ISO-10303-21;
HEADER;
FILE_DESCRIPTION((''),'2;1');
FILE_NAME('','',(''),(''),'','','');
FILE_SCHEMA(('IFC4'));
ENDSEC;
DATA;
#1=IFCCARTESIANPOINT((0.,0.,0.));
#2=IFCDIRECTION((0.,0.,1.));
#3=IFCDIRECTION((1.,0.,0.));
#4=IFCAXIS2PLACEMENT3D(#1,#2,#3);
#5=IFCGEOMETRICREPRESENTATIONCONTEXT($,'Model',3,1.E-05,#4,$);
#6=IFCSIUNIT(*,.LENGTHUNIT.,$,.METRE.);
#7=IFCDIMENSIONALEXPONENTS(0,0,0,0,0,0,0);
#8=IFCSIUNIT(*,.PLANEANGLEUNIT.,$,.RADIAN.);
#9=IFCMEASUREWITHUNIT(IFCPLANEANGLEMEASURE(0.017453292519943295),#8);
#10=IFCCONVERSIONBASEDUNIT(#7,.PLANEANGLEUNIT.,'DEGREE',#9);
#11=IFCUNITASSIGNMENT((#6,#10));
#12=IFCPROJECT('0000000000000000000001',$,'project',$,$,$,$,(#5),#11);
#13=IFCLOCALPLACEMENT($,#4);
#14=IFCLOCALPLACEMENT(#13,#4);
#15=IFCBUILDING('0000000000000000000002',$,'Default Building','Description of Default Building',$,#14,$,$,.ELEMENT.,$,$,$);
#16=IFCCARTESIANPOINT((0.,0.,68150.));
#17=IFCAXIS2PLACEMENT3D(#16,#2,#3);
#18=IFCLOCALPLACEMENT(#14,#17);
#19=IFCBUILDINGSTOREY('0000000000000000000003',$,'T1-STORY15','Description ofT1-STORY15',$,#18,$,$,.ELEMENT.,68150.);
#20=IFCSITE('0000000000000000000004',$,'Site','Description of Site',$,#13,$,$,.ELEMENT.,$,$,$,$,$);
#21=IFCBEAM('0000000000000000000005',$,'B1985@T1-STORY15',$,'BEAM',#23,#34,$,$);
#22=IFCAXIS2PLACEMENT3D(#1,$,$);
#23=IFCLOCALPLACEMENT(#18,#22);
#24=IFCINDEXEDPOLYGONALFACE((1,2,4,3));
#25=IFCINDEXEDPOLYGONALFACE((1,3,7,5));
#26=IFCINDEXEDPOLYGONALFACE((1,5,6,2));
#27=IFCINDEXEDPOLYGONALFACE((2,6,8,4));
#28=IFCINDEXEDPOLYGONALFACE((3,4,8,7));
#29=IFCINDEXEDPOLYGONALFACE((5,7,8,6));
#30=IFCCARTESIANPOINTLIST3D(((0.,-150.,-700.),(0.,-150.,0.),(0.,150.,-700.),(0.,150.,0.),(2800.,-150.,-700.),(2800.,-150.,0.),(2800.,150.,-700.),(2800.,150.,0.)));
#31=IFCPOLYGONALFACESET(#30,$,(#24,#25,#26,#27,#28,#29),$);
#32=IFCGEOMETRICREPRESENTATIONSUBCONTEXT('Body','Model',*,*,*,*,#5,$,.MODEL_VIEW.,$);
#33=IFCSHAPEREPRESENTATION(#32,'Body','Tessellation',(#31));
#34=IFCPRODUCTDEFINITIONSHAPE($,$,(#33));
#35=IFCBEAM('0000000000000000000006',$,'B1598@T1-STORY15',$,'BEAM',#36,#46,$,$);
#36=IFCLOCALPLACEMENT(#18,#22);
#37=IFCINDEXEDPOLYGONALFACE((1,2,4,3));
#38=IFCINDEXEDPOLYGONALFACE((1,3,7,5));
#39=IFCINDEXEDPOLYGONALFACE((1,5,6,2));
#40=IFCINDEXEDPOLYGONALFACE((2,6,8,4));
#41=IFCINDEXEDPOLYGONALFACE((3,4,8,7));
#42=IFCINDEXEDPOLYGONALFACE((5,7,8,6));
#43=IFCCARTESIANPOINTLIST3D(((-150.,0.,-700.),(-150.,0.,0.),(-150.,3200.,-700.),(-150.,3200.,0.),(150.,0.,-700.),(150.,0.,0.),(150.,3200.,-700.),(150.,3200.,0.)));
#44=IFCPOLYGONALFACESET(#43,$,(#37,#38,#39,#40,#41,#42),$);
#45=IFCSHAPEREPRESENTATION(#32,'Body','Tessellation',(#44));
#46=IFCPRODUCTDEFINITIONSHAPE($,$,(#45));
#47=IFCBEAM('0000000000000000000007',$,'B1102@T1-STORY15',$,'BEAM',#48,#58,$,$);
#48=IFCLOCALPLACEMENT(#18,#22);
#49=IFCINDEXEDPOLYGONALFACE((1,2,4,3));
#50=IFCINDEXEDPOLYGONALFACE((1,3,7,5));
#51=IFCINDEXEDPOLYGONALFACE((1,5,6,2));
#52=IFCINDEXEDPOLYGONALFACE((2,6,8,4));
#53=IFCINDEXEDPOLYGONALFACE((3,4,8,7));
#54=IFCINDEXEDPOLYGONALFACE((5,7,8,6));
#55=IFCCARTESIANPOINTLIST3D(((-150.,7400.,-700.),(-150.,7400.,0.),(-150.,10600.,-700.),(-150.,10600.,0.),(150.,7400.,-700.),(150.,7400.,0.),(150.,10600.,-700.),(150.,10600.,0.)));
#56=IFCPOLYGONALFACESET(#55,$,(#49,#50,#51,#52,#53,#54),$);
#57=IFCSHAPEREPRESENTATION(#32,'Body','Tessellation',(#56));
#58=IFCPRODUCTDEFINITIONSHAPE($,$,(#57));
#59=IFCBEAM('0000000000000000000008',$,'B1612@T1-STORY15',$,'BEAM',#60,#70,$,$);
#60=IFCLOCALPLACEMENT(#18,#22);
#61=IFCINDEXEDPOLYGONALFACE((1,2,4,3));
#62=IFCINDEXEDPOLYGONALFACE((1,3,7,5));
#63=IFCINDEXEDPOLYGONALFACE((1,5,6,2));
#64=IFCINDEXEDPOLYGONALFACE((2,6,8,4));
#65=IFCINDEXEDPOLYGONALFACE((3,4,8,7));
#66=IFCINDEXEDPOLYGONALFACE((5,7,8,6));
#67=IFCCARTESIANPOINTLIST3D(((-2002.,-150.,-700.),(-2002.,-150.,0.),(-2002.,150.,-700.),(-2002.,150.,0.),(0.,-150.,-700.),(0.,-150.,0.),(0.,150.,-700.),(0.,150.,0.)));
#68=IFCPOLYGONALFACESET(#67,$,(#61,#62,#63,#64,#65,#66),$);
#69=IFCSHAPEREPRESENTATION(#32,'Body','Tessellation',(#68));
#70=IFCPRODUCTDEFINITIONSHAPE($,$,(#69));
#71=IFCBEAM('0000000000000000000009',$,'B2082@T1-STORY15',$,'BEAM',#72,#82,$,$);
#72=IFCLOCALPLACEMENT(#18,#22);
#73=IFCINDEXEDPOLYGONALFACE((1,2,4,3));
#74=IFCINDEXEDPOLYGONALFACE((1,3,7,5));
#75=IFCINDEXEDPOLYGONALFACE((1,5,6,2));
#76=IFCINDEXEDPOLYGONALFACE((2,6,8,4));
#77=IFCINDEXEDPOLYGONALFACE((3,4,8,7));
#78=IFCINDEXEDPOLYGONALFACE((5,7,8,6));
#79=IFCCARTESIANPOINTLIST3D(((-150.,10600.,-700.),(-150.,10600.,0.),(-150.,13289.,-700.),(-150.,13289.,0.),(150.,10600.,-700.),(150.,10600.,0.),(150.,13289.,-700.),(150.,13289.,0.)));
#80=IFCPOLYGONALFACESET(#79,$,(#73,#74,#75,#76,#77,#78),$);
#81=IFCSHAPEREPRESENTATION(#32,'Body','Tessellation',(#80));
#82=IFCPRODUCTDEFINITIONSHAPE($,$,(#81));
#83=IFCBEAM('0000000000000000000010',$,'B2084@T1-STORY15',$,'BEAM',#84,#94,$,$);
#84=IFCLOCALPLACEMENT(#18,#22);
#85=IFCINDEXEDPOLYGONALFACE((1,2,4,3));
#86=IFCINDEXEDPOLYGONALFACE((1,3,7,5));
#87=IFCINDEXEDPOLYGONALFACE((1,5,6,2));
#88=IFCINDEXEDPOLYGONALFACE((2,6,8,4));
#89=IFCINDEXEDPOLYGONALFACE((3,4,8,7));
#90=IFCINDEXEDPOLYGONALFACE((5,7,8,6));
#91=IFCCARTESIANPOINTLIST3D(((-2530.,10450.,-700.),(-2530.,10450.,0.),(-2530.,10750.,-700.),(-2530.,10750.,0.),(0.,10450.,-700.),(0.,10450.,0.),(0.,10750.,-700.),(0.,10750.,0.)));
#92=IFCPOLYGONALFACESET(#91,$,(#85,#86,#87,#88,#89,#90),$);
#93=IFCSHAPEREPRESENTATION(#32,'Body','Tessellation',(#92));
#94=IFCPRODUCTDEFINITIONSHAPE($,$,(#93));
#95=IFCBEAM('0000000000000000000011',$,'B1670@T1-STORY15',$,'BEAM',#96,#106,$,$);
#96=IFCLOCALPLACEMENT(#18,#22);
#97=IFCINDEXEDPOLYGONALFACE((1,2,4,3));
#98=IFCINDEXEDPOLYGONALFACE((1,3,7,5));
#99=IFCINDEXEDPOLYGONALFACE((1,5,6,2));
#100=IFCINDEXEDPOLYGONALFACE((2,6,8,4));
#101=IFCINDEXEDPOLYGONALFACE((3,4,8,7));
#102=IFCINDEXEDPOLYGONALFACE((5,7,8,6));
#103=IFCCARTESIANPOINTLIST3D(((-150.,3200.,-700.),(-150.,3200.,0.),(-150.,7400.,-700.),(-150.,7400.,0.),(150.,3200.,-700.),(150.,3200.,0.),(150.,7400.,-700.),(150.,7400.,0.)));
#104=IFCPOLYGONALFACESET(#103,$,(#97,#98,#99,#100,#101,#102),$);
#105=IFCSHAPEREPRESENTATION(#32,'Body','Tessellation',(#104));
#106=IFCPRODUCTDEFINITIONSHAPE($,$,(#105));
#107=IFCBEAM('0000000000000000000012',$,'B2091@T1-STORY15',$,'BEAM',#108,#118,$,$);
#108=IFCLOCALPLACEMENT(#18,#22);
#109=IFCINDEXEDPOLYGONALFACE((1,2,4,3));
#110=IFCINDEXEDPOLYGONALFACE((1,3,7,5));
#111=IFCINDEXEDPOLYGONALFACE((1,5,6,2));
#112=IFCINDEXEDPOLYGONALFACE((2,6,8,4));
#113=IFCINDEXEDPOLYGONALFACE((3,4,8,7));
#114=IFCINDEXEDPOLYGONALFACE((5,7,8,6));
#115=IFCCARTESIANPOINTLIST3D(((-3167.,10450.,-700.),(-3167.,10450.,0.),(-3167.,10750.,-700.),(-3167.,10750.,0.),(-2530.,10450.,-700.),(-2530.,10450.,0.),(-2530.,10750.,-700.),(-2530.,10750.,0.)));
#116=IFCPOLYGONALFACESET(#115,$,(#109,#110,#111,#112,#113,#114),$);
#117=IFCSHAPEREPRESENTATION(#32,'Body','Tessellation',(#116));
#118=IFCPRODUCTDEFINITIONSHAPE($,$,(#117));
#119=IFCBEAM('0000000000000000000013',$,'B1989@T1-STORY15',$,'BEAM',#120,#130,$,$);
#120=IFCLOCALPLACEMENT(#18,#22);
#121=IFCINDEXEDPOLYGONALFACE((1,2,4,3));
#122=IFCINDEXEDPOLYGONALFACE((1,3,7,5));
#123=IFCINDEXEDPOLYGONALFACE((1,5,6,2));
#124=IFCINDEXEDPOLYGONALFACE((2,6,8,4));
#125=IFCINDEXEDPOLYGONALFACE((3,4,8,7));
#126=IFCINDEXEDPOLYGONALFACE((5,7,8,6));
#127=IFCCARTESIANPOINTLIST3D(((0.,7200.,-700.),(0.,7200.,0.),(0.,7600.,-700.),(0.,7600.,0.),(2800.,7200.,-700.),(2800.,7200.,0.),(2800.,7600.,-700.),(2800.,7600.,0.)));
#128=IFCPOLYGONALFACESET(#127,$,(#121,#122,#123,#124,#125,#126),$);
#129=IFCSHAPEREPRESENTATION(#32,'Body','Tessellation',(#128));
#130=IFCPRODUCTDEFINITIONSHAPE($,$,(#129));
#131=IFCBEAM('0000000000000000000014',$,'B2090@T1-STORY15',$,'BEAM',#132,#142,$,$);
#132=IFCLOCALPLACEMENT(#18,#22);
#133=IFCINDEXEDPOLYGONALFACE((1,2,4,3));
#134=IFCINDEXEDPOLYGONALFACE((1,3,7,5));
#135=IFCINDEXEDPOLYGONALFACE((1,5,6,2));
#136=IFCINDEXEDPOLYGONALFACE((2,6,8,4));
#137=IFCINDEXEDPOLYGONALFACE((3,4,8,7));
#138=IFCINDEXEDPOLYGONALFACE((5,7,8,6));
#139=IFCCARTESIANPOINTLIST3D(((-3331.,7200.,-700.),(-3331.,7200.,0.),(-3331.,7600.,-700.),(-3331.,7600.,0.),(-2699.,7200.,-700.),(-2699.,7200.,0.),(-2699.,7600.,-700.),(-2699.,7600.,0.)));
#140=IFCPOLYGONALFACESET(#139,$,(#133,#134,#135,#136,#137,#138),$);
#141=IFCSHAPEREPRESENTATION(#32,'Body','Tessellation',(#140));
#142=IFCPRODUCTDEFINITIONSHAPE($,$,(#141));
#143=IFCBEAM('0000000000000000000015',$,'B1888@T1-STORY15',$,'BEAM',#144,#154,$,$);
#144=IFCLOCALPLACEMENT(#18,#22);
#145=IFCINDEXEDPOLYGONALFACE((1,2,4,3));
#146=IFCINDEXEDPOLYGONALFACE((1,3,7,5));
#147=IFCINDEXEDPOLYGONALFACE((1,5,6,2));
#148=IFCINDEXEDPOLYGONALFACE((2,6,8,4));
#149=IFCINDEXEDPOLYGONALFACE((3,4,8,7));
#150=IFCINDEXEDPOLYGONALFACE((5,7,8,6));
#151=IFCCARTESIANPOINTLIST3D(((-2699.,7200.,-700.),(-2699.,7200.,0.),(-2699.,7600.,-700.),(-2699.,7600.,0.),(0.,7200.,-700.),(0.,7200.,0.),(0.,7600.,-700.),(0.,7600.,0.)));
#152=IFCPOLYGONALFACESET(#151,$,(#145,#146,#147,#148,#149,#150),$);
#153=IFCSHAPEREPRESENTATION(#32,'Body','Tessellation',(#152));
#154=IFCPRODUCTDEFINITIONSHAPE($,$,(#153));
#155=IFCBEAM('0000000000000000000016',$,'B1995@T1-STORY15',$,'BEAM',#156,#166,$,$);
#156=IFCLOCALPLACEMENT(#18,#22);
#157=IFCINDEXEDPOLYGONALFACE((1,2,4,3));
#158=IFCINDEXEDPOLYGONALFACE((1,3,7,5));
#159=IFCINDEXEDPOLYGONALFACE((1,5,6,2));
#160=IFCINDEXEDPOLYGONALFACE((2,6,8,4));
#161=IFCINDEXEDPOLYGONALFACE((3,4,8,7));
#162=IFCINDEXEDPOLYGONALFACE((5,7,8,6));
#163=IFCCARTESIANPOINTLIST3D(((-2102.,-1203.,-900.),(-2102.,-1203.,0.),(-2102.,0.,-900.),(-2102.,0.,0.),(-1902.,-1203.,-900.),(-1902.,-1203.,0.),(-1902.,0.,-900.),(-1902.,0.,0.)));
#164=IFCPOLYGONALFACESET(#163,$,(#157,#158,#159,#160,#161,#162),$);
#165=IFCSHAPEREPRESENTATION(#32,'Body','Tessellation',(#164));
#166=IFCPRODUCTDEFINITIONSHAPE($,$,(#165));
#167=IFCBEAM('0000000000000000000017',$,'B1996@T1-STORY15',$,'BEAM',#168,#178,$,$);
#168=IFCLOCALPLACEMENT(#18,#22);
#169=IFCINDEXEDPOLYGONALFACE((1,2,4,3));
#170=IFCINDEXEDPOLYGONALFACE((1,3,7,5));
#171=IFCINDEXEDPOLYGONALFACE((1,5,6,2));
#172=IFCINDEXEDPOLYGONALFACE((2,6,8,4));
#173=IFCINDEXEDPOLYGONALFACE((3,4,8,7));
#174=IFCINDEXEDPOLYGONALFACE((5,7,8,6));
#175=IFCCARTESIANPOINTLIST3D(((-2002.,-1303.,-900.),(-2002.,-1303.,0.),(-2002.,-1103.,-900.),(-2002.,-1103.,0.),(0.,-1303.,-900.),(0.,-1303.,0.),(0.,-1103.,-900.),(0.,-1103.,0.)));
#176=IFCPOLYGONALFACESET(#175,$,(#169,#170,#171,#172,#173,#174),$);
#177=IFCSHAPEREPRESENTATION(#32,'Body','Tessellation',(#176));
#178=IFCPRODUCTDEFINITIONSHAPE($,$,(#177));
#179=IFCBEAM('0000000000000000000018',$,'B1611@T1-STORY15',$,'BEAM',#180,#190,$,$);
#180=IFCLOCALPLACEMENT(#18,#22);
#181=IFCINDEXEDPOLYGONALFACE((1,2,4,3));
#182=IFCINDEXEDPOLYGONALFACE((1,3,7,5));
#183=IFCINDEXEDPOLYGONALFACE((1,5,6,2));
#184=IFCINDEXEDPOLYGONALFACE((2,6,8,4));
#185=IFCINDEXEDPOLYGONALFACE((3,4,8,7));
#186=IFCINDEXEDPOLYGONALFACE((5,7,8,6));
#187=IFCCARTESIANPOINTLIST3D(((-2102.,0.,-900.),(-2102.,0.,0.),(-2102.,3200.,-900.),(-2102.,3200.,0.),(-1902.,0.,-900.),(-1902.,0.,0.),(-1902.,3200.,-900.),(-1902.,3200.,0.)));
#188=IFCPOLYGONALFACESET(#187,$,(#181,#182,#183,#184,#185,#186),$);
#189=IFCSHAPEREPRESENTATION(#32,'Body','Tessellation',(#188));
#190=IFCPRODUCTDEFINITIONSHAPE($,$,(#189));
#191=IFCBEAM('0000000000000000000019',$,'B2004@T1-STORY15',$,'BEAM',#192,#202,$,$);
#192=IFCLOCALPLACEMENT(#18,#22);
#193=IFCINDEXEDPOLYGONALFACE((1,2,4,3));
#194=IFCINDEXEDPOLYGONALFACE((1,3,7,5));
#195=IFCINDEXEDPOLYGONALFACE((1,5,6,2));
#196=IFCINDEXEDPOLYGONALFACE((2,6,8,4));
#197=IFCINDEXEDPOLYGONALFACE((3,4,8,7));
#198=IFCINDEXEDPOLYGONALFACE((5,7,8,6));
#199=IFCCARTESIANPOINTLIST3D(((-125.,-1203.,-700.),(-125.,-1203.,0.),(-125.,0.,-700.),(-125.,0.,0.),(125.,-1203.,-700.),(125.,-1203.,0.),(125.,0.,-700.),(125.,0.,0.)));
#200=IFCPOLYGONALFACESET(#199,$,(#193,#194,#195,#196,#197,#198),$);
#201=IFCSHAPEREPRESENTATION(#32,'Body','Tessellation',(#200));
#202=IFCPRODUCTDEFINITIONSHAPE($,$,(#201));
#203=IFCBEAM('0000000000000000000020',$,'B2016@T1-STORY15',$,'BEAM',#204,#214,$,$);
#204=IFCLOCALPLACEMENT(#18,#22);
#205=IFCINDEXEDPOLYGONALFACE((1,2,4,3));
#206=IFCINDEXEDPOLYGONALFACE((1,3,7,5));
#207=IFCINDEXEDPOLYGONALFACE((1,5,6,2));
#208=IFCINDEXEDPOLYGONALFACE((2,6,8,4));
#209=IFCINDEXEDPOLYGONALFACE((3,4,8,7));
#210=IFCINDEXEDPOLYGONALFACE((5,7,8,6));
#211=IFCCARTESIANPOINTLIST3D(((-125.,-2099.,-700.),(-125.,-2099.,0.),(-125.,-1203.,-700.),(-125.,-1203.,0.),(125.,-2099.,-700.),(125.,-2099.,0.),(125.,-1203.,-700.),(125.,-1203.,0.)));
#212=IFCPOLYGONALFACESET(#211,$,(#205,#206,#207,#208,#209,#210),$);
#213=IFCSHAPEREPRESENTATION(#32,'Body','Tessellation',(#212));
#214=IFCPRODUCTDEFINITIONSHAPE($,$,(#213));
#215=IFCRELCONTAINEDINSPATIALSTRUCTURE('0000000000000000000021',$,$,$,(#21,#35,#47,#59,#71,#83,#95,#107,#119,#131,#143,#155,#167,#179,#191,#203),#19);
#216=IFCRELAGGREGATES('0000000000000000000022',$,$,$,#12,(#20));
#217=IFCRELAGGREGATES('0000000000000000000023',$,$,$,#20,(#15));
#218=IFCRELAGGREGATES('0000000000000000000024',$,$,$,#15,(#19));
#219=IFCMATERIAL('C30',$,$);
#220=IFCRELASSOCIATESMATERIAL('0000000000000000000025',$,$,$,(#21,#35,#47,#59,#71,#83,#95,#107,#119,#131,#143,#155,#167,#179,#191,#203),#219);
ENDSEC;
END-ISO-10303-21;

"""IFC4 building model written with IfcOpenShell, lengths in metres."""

from ifc_helpers import new_model, entity, si_unit, converted_unit, frame, origin_with_axes, place, context, subcontext, project, spatial, rectangle, extrude, material, element, save


model = new_model("IFC4")

# Units and contexts
model_context = context("Model", 3, precision=1e-05, world=origin_with_axes())
body_context = subcontext(model_context, "Body", "Model", "MODEL_VIEW")
ifc_project = project(units=[si_unit("LENGTHUNIT", "METRE"), converted_unit("PLANEANGLEUNIT", "DEGREE", entity("IfcPlaneAngleMeasure", 0.017453292519943295), si_unit("PLANEANGLEUNIT", "RADIAN"), dimensions=[0, 0, 0, 0, 0, 0, 0])], contexts=[model_context])

# Site, building, storey
site_placement = place(None, origin_with_axes())
site = spatial("IfcSite", under=ifc_project, at=site_placement, Name="Site", Description="Description of Site", CompositionType="ELEMENT")
building_placement = place(site_placement, origin_with_axes())
building = spatial("IfcBuilding", under=site, at=building_placement, Name="Default Building", Description="Description of Default Building", CompositionType="ELEMENT")
storey_placement = place(building_placement, frame((0.0, 0.0, 68150.0), z_axis=(0.0, 0.0, 1.0), x_axis=(1.0, 0.0, 0.0)))
storey = spatial("IfcBuildingStorey", under=building, at=storey_placement, Name="T1-STORY15", Description="Description ofT1-STORY15", CompositionType="ELEMENT", Elevation=68150.0)

# Beams
ifc_material_1 = material(Name="C30")
beam_1_placement = place(storey_placement, frame((0.0, 0.0, -350.0), z_axis=(1.0, 0.0, 0.0), x_axis=(0.0, 1.0, 0.0)))
element("IfcBeam", 1, at=beam_1_placement, inside=storey, material=ifc_material_1, Name="B1985@T1-STORY15", ObjectType="BEAM", context=body_context, shape_type="SweptSolid", body=[
    extrude(rectangle(XDim=300.0, YDim=700.0), origin_with_axes(), (0.0, 0.0, 1.0), 2800.0),
])
for number, where, z_axis, x_axis, name in (
    (2, (0.0, 0.0, -350.0), (0.0, 1.0, 0.0), (-1.0, 0.0, 0.0), "B1598@T1-STORY15"),
    (3, (0.0, 7400.0, -350.0), (0.0, 1.0, 0.0), (-1.0, 0.0, 0.0), "B1102@T1-STORY15"),
):
    element("IfcBeam", number, at=place(storey_placement, frame(where, z_axis=z_axis, x_axis=x_axis)), inside=storey, material=ifc_material_1, Name=name, ObjectType="BEAM", context=body_context, shape_type="SweptSolid", body=[
        extrude(rectangle(XDim=300.0, YDim=700.0), origin_with_axes(), (0.0, 0.0, 1.0), 3200.0),
    ])
beam_2_placement = place(storey_placement, frame((-2002.0, 0.0, -350.0), z_axis=(1.0, 0.0, 0.0), x_axis=(0.0, 1.0, 0.0)))
element("IfcBeam", 4, at=beam_2_placement, inside=storey, material=ifc_material_1, Name="B1612@T1-STORY15", ObjectType="BEAM", context=body_context, shape_type="SweptSolid", body=[
    extrude(rectangle(XDim=300.0, YDim=700.0), origin_with_axes(), (0.0, 0.0, 1.0), 2002.0),
])
beam_3_placement = place(storey_placement, frame((0.0, 10600.0, -350.0), z_axis=(0.0, 1.0, 0.0), x_axis=(-1.0, 0.0, 0.0)))
element("IfcBeam", 5, at=beam_3_placement, inside=storey, material=ifc_material_1, Name="B2082@T1-STORY15", ObjectType="BEAM", context=body_context, shape_type="SweptSolid", body=[
    extrude(rectangle(XDim=300.0, YDim=700.0), origin_with_axes(), (0.0, 0.0, 1.0), 2689.0),
])
beam_4_placement = place(storey_placement, frame((-2530.0, 10600.0, -350.0), z_axis=(1.0, 0.0, 0.0), x_axis=(0.0, 1.0, 0.0)))
element("IfcBeam", 6, at=beam_4_placement, inside=storey, material=ifc_material_1, Name="B2084@T1-STORY15", ObjectType="BEAM", context=body_context, shape_type="SweptSolid", body=[
    extrude(rectangle(XDim=300.0, YDim=700.0), origin_with_axes(), (0.0, 0.0, 1.0), 2530.0),
])
beam_5_placement = place(storey_placement, frame((0.0, 3200.0, -350.0), z_axis=(0.0, 1.0, 0.0), x_axis=(-1.0, 0.0, 0.0)))
element("IfcBeam", 7, at=beam_5_placement, inside=storey, material=ifc_material_1, Name="B1670@T1-STORY15", ObjectType="BEAM", context=body_context, shape_type="SweptSolid", body=[
    extrude(rectangle(XDim=300.0, YDim=700.0), origin_with_axes(), (0.0, 0.0, 1.0), 4200.0),
])
beam_6_placement = place(storey_placement, frame((-3167.0, 10600.0, -350.0), z_axis=(1.0, 0.0, 0.0), x_axis=(0.0, 1.0, 0.0)))
element("IfcBeam", 8, at=beam_6_placement, inside=storey, material=ifc_material_1, Name="B2091@T1-STORY15", ObjectType="BEAM", context=body_context, shape_type="SweptSolid", body=[
    extrude(rectangle(XDim=300.0, YDim=700.0), origin_with_axes(), (0.0, 0.0, 1.0), 637.0),
])
beam_7_placement = place(storey_placement, frame((0.0, 7400.0, -350.0), z_axis=(1.0, 0.0, 0.0), x_axis=(0.0, 1.0, 0.0)))
element("IfcBeam", 9, at=beam_7_placement, inside=storey, material=ifc_material_1, Name="B1989@T1-STORY15", ObjectType="BEAM", context=body_context, shape_type="SweptSolid", body=[
    extrude(rectangle(XDim=400.0, YDim=700.0), origin_with_axes(), (0.0, 0.0, 1.0), 2800.0),
])
beam_8_placement = place(storey_placement, frame((-3331.0, 7400.0, -350.0), z_axis=(1.0, 0.0, 0.0), x_axis=(0.0, 1.0, 0.0)))
element("IfcBeam", 10, at=beam_8_placement, inside=storey, material=ifc_material_1, Name="B2090@T1-STORY15", ObjectType="BEAM", context=body_context, shape_type="SweptSolid", body=[
    extrude(rectangle(XDim=400.0, YDim=700.0), origin_with_axes(), (0.0, 0.0, 1.0), 632.0),
])
beam_9_placement = place(storey_placement, frame((-2699.0, 7400.0, -350.0), z_axis=(1.0, 0.0, 0.0), x_axis=(0.0, 1.0, 0.0)))
element("IfcBeam", 11, at=beam_9_placement, inside=storey, material=ifc_material_1, Name="B1888@T1-STORY15", ObjectType="BEAM", context=body_context, shape_type="SweptSolid", body=[
    extrude(rectangle(XDim=400.0, YDim=700.0), origin_with_axes(), (0.0, 0.0, 1.0), 2699.0),
])
beam_10_placement = place(storey_placement, frame((-2002.0, -1203.0, -450.0), z_axis=(0.0, 1.0, 0.0), x_axis=(-1.0, 0.0, 0.0)))
element("IfcBeam", 12, at=beam_10_placement, inside=storey, material=ifc_material_1, Name="B1995@T1-STORY15", ObjectType="BEAM", context=body_context, shape_type="SweptSolid", body=[
    extrude(rectangle(XDim=200.0, YDim=900.0), origin_with_axes(), (0.0, 0.0, 1.0), 1203.0),
])
beam_11_placement = place(storey_placement, frame((-2002.0, -1203.0, -450.0), z_axis=(1.0, 0.0, 0.0), x_axis=(0.0, 1.0, 0.0)))
element("IfcBeam", 13, at=beam_11_placement, inside=storey, material=ifc_material_1, Name="B1996@T1-STORY15", ObjectType="BEAM", context=body_context, shape_type="SweptSolid", body=[
    extrude(rectangle(XDim=200.0, YDim=900.0), origin_with_axes(), (0.0, 0.0, 1.0), 2002.0),
])
beam_12_placement = place(storey_placement, frame((-2002.0, 0.0, -450.0), z_axis=(0.0, 1.0, 0.0), x_axis=(-1.0, 0.0, 0.0)))
element("IfcBeam", 14, at=beam_12_placement, inside=storey, material=ifc_material_1, Name="B1611@T1-STORY15", ObjectType="BEAM", context=body_context, shape_type="SweptSolid", body=[
    extrude(rectangle(XDim=200.0, YDim=900.0), origin_with_axes(), (0.0, 0.0, 1.0), 3200.0),
])
beam_13_placement = place(storey_placement, frame((0.0, -1203.0, -350.0), z_axis=(0.0, 1.0, 0.0), x_axis=(-1.0, 0.0, 0.0)))
element("IfcBeam", 15, at=beam_13_placement, inside=storey, material=ifc_material_1, Name="B2004@T1-STORY15", ObjectType="BEAM", context=body_context, shape_type="SweptSolid", body=[
    extrude(rectangle(XDim=250.0, YDim=700.0), origin_with_axes(), (0.0, 0.0, 1.0), 1203.0),
])
beam_14_placement = place(storey_placement, frame((0.0, -2099.0, -350.0), z_axis=(0.0, 1.0, 0.0), x_axis=(-1.0, 0.0, 0.0)))
element("IfcBeam", 16, at=beam_14_placement, inside=storey, material=ifc_material_1, Name="B2016@T1-STORY15", ObjectType="BEAM", context=body_context, shape_type="SweptSolid", body=[
    extrude(rectangle(XDim=250.0, YDim=700.0), origin_with_axes(), (0.0, 0.0, 1.0), 896.0),
])

save(model, "model.ifc")
